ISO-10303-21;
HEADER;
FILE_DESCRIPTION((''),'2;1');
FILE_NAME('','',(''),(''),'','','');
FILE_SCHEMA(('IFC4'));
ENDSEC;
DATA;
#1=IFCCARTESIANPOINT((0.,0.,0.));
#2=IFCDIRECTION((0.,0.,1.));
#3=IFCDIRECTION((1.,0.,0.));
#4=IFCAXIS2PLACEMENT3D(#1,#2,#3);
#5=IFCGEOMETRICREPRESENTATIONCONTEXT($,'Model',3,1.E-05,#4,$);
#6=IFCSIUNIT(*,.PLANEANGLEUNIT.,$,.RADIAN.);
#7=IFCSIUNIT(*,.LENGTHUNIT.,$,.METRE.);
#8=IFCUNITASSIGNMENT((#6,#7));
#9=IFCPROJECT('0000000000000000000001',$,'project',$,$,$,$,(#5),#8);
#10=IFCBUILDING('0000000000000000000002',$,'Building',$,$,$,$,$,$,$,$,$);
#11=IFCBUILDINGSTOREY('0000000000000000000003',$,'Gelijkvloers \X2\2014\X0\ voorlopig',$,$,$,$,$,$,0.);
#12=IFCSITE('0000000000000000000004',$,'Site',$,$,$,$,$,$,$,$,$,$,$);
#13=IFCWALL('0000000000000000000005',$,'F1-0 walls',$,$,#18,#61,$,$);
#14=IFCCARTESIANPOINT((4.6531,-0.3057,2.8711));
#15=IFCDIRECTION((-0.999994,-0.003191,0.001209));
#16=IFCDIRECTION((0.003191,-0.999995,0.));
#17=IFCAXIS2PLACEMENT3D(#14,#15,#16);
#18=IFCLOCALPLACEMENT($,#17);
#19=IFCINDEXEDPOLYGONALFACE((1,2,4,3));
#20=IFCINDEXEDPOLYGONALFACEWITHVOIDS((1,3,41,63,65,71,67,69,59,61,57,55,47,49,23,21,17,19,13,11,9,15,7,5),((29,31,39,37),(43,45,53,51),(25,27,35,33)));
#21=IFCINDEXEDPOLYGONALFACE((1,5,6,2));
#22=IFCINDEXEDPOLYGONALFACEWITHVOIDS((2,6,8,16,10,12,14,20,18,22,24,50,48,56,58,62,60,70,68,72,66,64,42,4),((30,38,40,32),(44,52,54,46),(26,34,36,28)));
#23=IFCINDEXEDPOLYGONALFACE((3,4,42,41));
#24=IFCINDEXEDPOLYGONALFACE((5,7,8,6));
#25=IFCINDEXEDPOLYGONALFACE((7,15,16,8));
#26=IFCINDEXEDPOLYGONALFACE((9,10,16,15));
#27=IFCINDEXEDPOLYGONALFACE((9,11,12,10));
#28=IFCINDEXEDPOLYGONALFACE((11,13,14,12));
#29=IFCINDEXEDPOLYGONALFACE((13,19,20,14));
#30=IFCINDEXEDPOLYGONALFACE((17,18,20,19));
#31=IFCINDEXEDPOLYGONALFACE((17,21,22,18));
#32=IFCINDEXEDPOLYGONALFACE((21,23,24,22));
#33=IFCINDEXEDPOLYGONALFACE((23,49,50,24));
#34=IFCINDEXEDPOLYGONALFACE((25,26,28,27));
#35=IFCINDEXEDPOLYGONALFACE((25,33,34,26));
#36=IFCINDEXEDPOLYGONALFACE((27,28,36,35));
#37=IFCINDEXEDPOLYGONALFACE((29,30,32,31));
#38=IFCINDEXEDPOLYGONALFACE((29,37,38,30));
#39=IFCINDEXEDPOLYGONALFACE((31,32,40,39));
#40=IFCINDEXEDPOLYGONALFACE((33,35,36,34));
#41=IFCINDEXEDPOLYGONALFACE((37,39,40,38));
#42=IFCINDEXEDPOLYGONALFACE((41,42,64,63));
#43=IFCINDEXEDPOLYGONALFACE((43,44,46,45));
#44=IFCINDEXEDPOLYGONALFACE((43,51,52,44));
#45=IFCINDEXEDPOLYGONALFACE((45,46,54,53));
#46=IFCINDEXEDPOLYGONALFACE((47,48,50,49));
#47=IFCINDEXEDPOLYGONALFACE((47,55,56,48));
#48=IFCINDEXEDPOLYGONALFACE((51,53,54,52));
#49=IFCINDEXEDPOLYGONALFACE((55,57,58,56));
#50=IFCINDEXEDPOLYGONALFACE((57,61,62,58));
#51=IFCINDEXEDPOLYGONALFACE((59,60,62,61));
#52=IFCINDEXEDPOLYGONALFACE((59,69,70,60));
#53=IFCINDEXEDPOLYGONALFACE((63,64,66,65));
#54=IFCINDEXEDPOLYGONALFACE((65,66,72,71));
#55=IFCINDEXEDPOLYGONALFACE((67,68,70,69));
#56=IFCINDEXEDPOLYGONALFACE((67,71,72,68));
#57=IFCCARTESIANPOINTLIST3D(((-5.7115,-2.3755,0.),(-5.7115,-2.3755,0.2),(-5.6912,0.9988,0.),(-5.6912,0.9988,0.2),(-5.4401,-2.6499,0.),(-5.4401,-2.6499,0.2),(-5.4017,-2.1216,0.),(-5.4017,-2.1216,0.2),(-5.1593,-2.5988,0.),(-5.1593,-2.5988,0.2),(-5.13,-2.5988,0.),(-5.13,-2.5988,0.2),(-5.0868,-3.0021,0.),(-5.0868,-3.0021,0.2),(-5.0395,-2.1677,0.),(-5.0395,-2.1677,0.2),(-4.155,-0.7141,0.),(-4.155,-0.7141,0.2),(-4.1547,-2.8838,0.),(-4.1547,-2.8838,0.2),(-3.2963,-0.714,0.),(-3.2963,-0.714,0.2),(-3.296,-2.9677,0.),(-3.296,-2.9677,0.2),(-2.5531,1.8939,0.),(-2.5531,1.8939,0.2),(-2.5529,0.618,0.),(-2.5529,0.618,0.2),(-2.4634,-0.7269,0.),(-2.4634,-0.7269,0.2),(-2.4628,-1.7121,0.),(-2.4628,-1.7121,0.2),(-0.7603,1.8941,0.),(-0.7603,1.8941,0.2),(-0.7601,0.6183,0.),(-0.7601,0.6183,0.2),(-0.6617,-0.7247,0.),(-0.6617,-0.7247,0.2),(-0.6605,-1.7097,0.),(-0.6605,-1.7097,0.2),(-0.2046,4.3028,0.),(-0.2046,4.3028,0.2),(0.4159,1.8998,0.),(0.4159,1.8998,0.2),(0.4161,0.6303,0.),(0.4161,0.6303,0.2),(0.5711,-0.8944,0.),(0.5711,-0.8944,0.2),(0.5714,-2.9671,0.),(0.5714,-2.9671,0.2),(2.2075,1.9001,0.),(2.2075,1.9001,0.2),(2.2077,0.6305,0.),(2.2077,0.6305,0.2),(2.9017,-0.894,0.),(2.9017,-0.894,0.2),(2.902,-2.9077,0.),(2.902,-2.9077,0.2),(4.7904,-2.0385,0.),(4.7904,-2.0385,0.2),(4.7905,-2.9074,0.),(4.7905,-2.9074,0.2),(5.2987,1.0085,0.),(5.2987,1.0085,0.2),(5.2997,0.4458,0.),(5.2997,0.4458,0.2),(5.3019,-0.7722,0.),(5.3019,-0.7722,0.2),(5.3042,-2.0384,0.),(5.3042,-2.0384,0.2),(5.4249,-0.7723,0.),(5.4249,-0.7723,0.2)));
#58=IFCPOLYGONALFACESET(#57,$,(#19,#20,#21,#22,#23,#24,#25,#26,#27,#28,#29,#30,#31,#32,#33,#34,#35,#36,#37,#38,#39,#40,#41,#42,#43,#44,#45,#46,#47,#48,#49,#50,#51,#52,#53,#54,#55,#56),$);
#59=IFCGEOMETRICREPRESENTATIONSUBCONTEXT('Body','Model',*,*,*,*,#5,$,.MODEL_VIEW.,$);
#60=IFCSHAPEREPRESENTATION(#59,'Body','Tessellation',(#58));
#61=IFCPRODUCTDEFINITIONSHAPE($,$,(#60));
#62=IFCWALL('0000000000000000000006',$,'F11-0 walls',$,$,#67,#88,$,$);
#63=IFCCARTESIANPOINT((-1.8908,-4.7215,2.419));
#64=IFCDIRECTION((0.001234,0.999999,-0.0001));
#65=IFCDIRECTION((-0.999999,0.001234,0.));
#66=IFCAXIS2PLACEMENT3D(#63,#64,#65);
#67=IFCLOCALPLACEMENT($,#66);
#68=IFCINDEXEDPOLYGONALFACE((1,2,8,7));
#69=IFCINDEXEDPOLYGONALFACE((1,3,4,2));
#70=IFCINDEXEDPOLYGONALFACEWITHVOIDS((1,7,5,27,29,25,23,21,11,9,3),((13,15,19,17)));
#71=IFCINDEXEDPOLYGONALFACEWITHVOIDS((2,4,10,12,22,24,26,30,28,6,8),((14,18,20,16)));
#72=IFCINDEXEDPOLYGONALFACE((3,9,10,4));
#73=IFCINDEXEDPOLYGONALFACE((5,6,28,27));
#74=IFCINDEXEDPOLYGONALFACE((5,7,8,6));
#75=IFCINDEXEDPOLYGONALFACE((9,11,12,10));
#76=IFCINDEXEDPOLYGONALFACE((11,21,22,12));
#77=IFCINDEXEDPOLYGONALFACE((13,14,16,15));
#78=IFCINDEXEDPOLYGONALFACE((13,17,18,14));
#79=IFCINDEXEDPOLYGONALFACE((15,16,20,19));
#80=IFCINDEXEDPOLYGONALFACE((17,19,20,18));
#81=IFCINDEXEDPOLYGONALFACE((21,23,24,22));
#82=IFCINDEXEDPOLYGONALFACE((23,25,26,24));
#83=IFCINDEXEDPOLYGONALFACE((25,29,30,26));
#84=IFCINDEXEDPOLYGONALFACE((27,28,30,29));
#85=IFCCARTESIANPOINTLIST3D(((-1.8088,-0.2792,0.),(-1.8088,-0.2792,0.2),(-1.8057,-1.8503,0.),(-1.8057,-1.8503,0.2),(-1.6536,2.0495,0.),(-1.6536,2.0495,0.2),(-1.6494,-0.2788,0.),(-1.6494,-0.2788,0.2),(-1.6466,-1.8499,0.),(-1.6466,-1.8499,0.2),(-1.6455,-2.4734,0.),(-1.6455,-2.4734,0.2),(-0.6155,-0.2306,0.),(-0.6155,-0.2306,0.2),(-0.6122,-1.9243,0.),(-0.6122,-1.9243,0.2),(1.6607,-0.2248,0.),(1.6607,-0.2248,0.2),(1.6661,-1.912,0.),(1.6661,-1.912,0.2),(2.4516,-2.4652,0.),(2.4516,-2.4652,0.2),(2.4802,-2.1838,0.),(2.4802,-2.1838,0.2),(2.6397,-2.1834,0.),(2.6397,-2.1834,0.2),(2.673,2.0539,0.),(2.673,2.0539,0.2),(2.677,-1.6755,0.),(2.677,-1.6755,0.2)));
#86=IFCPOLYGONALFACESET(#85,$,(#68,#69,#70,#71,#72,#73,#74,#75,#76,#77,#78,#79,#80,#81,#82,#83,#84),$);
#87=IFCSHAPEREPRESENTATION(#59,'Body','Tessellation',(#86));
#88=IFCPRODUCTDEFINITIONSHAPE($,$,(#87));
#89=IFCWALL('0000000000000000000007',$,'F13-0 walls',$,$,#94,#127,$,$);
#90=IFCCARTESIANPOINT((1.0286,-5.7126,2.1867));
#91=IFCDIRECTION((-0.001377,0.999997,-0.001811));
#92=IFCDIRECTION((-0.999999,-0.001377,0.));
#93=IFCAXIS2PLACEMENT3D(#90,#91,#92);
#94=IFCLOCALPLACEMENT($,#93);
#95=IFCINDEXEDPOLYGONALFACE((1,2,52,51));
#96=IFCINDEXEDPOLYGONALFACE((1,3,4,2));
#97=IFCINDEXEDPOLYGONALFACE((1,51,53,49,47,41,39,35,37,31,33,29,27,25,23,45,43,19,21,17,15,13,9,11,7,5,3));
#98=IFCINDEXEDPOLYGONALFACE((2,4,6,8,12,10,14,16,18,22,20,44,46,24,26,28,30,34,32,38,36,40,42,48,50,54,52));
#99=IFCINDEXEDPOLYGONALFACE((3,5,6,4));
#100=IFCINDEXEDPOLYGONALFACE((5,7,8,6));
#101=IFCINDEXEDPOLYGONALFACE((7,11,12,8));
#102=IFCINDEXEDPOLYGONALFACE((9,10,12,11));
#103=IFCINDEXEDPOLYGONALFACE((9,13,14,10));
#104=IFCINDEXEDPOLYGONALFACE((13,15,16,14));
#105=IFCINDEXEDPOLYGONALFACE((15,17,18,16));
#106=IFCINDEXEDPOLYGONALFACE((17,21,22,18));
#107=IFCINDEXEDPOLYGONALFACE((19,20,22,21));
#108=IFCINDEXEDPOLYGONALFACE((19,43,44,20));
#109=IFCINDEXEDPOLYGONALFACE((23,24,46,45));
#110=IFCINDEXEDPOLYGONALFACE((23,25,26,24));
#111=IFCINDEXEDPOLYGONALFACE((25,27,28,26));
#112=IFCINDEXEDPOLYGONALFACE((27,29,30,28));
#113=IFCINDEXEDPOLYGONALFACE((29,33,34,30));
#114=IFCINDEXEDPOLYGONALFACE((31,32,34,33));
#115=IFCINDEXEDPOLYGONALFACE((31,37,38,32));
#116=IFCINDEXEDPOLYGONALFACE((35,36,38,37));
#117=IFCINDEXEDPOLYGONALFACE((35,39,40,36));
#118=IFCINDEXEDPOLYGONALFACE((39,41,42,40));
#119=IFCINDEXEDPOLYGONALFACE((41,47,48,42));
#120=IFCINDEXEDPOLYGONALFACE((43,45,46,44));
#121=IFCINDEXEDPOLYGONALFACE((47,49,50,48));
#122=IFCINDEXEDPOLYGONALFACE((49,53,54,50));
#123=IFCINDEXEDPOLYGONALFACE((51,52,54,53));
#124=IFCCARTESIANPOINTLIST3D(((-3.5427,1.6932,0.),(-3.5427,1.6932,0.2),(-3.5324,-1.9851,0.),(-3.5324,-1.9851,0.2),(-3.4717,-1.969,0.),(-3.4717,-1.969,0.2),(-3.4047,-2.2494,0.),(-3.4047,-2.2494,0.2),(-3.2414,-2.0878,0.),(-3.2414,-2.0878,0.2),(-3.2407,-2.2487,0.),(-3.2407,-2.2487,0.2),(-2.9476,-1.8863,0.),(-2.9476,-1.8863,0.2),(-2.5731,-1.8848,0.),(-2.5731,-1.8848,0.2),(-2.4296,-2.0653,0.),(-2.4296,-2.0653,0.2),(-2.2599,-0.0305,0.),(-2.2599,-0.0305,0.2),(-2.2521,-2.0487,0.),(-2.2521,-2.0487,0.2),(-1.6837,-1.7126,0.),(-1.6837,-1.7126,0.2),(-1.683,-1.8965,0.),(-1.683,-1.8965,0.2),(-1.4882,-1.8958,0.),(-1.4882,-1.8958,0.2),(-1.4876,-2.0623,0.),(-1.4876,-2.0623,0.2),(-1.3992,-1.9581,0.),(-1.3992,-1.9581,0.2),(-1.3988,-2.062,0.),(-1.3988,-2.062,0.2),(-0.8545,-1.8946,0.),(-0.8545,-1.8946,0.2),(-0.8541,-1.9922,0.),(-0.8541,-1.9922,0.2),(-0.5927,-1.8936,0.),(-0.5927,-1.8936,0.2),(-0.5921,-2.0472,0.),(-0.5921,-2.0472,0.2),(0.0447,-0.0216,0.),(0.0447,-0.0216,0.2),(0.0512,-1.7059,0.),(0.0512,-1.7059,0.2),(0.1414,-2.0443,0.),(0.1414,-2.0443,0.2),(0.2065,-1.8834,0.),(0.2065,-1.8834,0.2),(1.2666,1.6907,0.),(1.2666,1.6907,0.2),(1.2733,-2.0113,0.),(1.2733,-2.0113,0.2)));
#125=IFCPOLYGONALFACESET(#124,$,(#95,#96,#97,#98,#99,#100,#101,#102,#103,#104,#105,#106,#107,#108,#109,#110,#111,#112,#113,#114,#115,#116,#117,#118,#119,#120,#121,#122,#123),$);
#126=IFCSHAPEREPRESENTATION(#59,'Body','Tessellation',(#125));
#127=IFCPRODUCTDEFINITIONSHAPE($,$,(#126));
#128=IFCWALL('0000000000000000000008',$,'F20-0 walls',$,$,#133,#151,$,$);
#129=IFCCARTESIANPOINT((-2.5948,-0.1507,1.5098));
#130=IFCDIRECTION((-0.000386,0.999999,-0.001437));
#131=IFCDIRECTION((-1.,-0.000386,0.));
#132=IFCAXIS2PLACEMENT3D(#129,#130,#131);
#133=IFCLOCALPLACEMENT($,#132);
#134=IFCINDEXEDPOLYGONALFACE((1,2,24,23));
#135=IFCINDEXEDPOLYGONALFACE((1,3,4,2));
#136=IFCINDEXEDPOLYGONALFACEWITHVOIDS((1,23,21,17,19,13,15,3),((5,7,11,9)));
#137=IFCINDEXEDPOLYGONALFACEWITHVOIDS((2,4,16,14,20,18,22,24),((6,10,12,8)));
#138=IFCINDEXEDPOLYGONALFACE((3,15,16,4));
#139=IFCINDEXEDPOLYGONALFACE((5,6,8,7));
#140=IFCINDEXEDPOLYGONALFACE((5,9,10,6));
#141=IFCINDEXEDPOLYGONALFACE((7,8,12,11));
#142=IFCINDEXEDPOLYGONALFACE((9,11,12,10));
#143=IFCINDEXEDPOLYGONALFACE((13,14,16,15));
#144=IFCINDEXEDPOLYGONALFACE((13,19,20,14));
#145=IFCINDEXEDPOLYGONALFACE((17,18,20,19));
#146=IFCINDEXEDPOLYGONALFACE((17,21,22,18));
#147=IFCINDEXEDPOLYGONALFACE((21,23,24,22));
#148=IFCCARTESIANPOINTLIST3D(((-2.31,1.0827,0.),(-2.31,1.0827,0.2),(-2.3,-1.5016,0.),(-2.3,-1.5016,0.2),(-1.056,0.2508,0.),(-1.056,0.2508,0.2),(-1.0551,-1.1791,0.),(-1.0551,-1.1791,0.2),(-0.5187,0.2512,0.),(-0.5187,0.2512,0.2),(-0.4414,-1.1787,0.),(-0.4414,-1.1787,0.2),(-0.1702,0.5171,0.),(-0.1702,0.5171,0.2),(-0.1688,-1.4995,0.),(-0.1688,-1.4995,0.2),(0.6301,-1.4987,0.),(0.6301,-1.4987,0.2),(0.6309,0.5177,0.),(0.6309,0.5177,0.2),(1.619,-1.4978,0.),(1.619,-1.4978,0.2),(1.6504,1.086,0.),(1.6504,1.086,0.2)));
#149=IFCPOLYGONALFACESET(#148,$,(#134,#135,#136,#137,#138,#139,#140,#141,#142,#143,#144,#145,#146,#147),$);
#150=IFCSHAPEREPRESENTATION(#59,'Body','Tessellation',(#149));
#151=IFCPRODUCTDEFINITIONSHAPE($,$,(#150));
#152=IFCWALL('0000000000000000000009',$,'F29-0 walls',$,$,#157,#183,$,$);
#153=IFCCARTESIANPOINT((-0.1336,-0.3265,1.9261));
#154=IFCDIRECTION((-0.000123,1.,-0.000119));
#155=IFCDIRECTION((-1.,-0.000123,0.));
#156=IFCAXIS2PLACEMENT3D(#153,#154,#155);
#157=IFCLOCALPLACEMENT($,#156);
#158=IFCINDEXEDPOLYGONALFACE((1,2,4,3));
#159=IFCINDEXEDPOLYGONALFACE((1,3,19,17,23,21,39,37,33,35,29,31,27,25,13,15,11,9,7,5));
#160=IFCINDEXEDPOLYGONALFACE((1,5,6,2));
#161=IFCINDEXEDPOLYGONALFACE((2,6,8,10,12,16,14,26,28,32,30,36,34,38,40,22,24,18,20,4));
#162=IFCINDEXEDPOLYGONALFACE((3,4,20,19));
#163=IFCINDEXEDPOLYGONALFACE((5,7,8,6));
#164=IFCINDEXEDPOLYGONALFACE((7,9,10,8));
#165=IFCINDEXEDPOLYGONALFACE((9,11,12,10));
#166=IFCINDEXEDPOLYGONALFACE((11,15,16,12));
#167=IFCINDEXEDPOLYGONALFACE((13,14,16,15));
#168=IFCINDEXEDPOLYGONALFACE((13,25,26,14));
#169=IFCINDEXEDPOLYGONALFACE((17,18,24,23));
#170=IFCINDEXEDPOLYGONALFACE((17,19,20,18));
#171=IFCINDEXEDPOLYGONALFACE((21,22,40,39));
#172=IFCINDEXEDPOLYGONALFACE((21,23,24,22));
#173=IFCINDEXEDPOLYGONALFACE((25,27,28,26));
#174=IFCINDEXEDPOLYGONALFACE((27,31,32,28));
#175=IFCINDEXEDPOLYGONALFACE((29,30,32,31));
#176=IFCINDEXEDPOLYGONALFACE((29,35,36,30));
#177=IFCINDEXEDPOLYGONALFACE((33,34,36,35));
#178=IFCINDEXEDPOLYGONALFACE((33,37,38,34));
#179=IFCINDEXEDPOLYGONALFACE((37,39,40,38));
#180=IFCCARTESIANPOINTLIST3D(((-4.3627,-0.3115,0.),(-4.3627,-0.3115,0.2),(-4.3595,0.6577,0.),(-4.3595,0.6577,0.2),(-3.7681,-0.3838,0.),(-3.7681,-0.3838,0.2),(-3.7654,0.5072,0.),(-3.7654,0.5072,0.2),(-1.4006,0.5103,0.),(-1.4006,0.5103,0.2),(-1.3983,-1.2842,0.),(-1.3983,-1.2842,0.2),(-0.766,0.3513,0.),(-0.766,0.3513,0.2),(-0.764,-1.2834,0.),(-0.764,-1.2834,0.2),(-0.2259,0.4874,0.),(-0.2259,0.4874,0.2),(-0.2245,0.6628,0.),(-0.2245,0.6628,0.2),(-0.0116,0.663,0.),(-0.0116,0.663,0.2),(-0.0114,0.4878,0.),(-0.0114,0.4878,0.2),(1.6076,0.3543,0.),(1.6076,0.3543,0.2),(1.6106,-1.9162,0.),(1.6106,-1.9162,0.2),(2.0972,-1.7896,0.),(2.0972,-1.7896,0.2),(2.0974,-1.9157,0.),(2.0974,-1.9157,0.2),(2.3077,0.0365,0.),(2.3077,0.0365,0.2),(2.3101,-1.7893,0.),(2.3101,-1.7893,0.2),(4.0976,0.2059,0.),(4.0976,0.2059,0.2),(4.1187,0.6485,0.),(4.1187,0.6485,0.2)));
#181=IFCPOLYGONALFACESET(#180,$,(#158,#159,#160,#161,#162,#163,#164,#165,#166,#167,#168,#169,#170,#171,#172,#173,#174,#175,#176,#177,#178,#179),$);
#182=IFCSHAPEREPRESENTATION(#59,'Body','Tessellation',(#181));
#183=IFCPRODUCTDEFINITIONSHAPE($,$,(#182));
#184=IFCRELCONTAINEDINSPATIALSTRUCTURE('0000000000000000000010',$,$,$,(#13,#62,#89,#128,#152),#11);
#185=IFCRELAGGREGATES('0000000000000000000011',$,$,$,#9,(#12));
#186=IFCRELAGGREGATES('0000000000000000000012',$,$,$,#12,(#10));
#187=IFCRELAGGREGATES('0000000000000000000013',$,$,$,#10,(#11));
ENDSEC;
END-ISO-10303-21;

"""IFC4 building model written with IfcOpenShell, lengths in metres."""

from ifc_helpers import new_model, si_unit, frame, origin_with_axes, place, context, subcontext, project, spatial, polyline, outline, extrude, element, save


model = new_model("IFC4")

# Units and contexts
model_context = context("Model", 3, precision=1e-05, world=origin_with_axes())
body_context = subcontext(model_context, "Body", "Model", "MODEL_VIEW")
ifc_project = project(units=[si_unit("PLANEANGLEUNIT", "RADIAN"), si_unit("LENGTHUNIT", "METRE")], contexts=[model_context])

# Site, building, storey
site = spatial("IfcSite", under=ifc_project, Name="Site")
building = spatial("IfcBuilding", under=site, Name="Building")
storey = spatial("IfcBuildingStorey", under=building, Name="Gelijkvloers — voorlopig", Elevation=0.0)

# Wall, openings
wall_1_placement = place(None, frame((4.6531, -0.3057, 2.8711), z_axis=(-0.999994, -0.003191, 0.001209), x_axis=(0.003191, -0.999995, 0.0)))
wall_1 = element("IfcWall", 1, at=wall_1_placement, inside=storey, Name="F1-0 walls", context=body_context, shape_type="SweptSolid", body=[
    extrude(outline(polyline([(-5.0868, -3.0021), (-4.1547, -2.8838), (-4.155, -0.7141), (-3.2963, -0.714), (-3.296, -2.9677), (0.5714, -2.9671), (0.5711, -0.8944), (2.9017, -0.894), (2.902, -2.9077), (4.7905, -2.9074), (4.7904, -2.0385), (5.3042, -2.0384), (5.3019, -0.7722), (5.4249, -0.7723), (5.2997, 0.4458), (5.2987, 1.0085), (-0.2046, 4.3028), (-5.6912, 0.9988), (-5.7115, -2.3755), (-5.4401, -2.6499), (-5.4017, -2.1216), (-5.0395, -2.1677), (-5.1593, -2.5988), (-5.13, -2.5988), (-5.0868, -3.0021)])), origin_with_axes(), (0.0, 0.0, 1.0), 0.2),
])
opening_1_placement = place(wall_1_placement, frame((0.0, 0.0, -0.05), z_axis=(0.0, 0.0, 1.0), x_axis=(1.0, 0.0, 0.0)))
element("IfcOpeningElement", 2, at=opening_1_placement, cuts=wall_1, PredefinedType="OPENING", context=body_context, shape_type="SweptSolid", body=[
    extrude(outline(polyline([(-2.4634, -0.7269), (-0.6617, -0.7247), (-0.6605, -1.7097), (-2.4628, -1.7121), (-2.4634, -0.7269)])), origin_with_axes(), (0.0, 0.0, 1.0), 0.3),
])
opening_2_placement = place(wall_1_placement, frame((0.0, 0.0, -0.05), z_axis=(0.0, 0.0, 1.0), x_axis=(1.0, 0.0, 0.0)))
element("IfcOpeningElement", 3, at=opening_2_placement, cuts=wall_1, PredefinedType="OPENING", context=body_context, shape_type="SweptSolid", body=[
    extrude(outline(polyline([(-0.7603, 1.8941), (-0.7601, 0.6183), (-2.5529, 0.618), (-2.5531, 1.8939), (-0.7603, 1.8941)])), origin_with_axes(), (0.0, 0.0, 1.0), 0.3),
])
opening_3_placement = place(wall_1_placement, frame((0.0, 0.0, -0.05), z_axis=(0.0, 0.0, 1.0), x_axis=(1.0, 0.0, 0.0)))
element("IfcOpeningElement", 4, at=opening_3_placement, cuts=wall_1, PredefinedType="OPENING", context=body_context, shape_type="SweptSolid", body=[
    extrude(outline(polyline([(2.2075, 1.9001), (2.2077, 0.6305), (0.4161, 0.6303), (0.4159, 1.8998), (2.2075, 1.9001)])), origin_with_axes(), (0.0, 0.0, 1.0), 0.3),
])

# Wall, opening
wall_2_placement = place(None, frame((-1.8908, -4.7215, 2.419), z_axis=(0.001234, 0.999999, -0.0001), x_axis=(-0.999999, 0.001234, 0.0)))
wall_2 = element("IfcWall", 5, at=wall_2_placement, inside=storey, Name="F11-0 walls", context=body_context, shape_type="SweptSolid", body=[
    extrude(outline(polyline([(-1.6455, -2.4734), (2.4516, -2.4652), (2.4802, -2.1838), (2.6397, -2.1834), (2.677, -1.6755), (2.673, 2.0539), (-1.6536, 2.0495), (-1.6494, -0.2788), (-1.8088, -0.2792), (-1.8057, -1.8503), (-1.6466, -1.8499), (-1.6455, -2.4734)])), origin_with_axes(), (0.0, 0.0, 1.0), 0.2),
])
opening_4_placement = place(wall_2_placement, frame((0.0, 0.0, -0.05), z_axis=(0.0, 0.0, 1.0), x_axis=(1.0, 0.0, 0.0)))
element("IfcOpeningElement", 6, at=opening_4_placement, cuts=wall_2, PredefinedType="OPENING", context=body_context, shape_type="SweptSolid", body=[
    extrude(outline(polyline([(-0.6122, -1.9243), (-0.6155, -0.2306), (1.6607, -0.2248), (1.6661, -1.912), (-0.6122, -1.9243)])), origin_with_axes(), (0.0, 0.0, 1.0), 0.3),
])

# Wall
wall_3_placement = place(None, frame((1.0286, -5.7126, 2.1867), z_axis=(-0.001377, 0.999997, -0.001811), x_axis=(-0.999999, -0.001377, 0.0)))
element("IfcWall", 7, at=wall_3_placement, inside=storey, Name="F13-0 walls", context=body_context, shape_type="SweptSolid", body=[
    extrude(outline(polyline([(-3.4047, -2.2494), (-3.2407, -2.2487), (-3.2414, -2.0878), (-2.9476, -1.8863), (-2.5731, -1.8848), (-2.4296, -2.0653), (-2.2521, -2.0487), (-2.2599, -0.0305), (0.0447, -0.0216), (0.0512, -1.7059), (-1.6837, -1.7126), (-1.683, -1.8965), (-1.4882, -1.8958), (-1.4876, -2.0623), (-1.3988, -2.062), (-1.3992, -1.9581), (-0.8541, -1.9922), (-0.8545, -1.8946), (-0.5927, -1.8936), (-0.5921, -2.0472), (0.1414, -2.0443), (0.2065, -1.8834), (1.2733, -2.0113), (1.2666, 1.6907), (-3.5427, 1.6932), (-3.5324, -1.9851), (-3.4717, -1.969), (-3.4047, -2.2494)])), origin_with_axes(), (0.0, 0.0, 1.0), 0.2),
])

# Wall, opening
wall_4_placement = place(None, frame((-2.5948, -0.1507, 1.5098), z_axis=(-0.000386, 0.999999, -0.001437), x_axis=(-1.0, -0.000386, 0.0)))
wall_4 = element("IfcWall", 8, at=wall_4_placement, inside=storey, Name="F20-0 walls", context=body_context, shape_type="SweptSolid", body=[
    extrude(outline(polyline([(-2.3, -1.5016), (-0.1688, -1.4995), (-0.1702, 0.5171), (0.6309, 0.5177), (0.6301, -1.4987), (1.619, -1.4978), (1.6504, 1.086), (-2.31, 1.0827), (-2.3, -1.5016)])), origin_with_axes(), (0.0, 0.0, 1.0), 0.2),
])
opening_5_placement = place(wall_4_placement, frame((0.0, 0.0, -0.05), z_axis=(0.0, 0.0, 1.0), x_axis=(1.0, 0.0, 0.0)))
element("IfcOpeningElement", 9, at=opening_5_placement, cuts=wall_4, PredefinedType="OPENING", context=body_context, shape_type="SweptSolid", body=[
    extrude(outline(polyline([(-1.0551, -1.1791), (-1.056, 0.2508), (-0.5187, 0.2512), (-0.4414, -1.1787), (-1.0551, -1.1791)])), origin_with_axes(), (0.0, 0.0, 1.0), 0.3),
])

# Wall
wall_5_placement = place(None, frame((-0.1336, -0.3265, 1.9261), z_axis=(-0.000123, 1.0, -0.000119), x_axis=(-1.0, -0.000123, 0.0)))
element("IfcWall", 10, at=wall_5_placement, inside=storey, Name="F29-0 walls", context=body_context, shape_type="SweptSolid", body=[
    extrude(outline(polyline([(1.6106, -1.9162), (2.0974, -1.9157), (2.0972, -1.7896), (2.3101, -1.7893), (2.3077, 0.0365), (4.0976, 0.2059), (4.1187, 0.6485), (-0.0116, 0.663), (-0.0114, 0.4878), (-0.2259, 0.4874), (-0.2245, 0.6628), (-4.3595, 0.6577), (-4.3627, -0.3115), (-3.7681, -0.3838), (-3.7654, 0.5072), (-1.4006, 0.5103), (-1.3983, -1.2842), (-0.764, -1.2834), (-0.766, 0.3513), (1.6076, 0.3543), (1.6106, -1.9162)])), origin_with_axes(), (0.0, 0.0, 1.0), 0.2),
])

save(model, "model.ifc")
